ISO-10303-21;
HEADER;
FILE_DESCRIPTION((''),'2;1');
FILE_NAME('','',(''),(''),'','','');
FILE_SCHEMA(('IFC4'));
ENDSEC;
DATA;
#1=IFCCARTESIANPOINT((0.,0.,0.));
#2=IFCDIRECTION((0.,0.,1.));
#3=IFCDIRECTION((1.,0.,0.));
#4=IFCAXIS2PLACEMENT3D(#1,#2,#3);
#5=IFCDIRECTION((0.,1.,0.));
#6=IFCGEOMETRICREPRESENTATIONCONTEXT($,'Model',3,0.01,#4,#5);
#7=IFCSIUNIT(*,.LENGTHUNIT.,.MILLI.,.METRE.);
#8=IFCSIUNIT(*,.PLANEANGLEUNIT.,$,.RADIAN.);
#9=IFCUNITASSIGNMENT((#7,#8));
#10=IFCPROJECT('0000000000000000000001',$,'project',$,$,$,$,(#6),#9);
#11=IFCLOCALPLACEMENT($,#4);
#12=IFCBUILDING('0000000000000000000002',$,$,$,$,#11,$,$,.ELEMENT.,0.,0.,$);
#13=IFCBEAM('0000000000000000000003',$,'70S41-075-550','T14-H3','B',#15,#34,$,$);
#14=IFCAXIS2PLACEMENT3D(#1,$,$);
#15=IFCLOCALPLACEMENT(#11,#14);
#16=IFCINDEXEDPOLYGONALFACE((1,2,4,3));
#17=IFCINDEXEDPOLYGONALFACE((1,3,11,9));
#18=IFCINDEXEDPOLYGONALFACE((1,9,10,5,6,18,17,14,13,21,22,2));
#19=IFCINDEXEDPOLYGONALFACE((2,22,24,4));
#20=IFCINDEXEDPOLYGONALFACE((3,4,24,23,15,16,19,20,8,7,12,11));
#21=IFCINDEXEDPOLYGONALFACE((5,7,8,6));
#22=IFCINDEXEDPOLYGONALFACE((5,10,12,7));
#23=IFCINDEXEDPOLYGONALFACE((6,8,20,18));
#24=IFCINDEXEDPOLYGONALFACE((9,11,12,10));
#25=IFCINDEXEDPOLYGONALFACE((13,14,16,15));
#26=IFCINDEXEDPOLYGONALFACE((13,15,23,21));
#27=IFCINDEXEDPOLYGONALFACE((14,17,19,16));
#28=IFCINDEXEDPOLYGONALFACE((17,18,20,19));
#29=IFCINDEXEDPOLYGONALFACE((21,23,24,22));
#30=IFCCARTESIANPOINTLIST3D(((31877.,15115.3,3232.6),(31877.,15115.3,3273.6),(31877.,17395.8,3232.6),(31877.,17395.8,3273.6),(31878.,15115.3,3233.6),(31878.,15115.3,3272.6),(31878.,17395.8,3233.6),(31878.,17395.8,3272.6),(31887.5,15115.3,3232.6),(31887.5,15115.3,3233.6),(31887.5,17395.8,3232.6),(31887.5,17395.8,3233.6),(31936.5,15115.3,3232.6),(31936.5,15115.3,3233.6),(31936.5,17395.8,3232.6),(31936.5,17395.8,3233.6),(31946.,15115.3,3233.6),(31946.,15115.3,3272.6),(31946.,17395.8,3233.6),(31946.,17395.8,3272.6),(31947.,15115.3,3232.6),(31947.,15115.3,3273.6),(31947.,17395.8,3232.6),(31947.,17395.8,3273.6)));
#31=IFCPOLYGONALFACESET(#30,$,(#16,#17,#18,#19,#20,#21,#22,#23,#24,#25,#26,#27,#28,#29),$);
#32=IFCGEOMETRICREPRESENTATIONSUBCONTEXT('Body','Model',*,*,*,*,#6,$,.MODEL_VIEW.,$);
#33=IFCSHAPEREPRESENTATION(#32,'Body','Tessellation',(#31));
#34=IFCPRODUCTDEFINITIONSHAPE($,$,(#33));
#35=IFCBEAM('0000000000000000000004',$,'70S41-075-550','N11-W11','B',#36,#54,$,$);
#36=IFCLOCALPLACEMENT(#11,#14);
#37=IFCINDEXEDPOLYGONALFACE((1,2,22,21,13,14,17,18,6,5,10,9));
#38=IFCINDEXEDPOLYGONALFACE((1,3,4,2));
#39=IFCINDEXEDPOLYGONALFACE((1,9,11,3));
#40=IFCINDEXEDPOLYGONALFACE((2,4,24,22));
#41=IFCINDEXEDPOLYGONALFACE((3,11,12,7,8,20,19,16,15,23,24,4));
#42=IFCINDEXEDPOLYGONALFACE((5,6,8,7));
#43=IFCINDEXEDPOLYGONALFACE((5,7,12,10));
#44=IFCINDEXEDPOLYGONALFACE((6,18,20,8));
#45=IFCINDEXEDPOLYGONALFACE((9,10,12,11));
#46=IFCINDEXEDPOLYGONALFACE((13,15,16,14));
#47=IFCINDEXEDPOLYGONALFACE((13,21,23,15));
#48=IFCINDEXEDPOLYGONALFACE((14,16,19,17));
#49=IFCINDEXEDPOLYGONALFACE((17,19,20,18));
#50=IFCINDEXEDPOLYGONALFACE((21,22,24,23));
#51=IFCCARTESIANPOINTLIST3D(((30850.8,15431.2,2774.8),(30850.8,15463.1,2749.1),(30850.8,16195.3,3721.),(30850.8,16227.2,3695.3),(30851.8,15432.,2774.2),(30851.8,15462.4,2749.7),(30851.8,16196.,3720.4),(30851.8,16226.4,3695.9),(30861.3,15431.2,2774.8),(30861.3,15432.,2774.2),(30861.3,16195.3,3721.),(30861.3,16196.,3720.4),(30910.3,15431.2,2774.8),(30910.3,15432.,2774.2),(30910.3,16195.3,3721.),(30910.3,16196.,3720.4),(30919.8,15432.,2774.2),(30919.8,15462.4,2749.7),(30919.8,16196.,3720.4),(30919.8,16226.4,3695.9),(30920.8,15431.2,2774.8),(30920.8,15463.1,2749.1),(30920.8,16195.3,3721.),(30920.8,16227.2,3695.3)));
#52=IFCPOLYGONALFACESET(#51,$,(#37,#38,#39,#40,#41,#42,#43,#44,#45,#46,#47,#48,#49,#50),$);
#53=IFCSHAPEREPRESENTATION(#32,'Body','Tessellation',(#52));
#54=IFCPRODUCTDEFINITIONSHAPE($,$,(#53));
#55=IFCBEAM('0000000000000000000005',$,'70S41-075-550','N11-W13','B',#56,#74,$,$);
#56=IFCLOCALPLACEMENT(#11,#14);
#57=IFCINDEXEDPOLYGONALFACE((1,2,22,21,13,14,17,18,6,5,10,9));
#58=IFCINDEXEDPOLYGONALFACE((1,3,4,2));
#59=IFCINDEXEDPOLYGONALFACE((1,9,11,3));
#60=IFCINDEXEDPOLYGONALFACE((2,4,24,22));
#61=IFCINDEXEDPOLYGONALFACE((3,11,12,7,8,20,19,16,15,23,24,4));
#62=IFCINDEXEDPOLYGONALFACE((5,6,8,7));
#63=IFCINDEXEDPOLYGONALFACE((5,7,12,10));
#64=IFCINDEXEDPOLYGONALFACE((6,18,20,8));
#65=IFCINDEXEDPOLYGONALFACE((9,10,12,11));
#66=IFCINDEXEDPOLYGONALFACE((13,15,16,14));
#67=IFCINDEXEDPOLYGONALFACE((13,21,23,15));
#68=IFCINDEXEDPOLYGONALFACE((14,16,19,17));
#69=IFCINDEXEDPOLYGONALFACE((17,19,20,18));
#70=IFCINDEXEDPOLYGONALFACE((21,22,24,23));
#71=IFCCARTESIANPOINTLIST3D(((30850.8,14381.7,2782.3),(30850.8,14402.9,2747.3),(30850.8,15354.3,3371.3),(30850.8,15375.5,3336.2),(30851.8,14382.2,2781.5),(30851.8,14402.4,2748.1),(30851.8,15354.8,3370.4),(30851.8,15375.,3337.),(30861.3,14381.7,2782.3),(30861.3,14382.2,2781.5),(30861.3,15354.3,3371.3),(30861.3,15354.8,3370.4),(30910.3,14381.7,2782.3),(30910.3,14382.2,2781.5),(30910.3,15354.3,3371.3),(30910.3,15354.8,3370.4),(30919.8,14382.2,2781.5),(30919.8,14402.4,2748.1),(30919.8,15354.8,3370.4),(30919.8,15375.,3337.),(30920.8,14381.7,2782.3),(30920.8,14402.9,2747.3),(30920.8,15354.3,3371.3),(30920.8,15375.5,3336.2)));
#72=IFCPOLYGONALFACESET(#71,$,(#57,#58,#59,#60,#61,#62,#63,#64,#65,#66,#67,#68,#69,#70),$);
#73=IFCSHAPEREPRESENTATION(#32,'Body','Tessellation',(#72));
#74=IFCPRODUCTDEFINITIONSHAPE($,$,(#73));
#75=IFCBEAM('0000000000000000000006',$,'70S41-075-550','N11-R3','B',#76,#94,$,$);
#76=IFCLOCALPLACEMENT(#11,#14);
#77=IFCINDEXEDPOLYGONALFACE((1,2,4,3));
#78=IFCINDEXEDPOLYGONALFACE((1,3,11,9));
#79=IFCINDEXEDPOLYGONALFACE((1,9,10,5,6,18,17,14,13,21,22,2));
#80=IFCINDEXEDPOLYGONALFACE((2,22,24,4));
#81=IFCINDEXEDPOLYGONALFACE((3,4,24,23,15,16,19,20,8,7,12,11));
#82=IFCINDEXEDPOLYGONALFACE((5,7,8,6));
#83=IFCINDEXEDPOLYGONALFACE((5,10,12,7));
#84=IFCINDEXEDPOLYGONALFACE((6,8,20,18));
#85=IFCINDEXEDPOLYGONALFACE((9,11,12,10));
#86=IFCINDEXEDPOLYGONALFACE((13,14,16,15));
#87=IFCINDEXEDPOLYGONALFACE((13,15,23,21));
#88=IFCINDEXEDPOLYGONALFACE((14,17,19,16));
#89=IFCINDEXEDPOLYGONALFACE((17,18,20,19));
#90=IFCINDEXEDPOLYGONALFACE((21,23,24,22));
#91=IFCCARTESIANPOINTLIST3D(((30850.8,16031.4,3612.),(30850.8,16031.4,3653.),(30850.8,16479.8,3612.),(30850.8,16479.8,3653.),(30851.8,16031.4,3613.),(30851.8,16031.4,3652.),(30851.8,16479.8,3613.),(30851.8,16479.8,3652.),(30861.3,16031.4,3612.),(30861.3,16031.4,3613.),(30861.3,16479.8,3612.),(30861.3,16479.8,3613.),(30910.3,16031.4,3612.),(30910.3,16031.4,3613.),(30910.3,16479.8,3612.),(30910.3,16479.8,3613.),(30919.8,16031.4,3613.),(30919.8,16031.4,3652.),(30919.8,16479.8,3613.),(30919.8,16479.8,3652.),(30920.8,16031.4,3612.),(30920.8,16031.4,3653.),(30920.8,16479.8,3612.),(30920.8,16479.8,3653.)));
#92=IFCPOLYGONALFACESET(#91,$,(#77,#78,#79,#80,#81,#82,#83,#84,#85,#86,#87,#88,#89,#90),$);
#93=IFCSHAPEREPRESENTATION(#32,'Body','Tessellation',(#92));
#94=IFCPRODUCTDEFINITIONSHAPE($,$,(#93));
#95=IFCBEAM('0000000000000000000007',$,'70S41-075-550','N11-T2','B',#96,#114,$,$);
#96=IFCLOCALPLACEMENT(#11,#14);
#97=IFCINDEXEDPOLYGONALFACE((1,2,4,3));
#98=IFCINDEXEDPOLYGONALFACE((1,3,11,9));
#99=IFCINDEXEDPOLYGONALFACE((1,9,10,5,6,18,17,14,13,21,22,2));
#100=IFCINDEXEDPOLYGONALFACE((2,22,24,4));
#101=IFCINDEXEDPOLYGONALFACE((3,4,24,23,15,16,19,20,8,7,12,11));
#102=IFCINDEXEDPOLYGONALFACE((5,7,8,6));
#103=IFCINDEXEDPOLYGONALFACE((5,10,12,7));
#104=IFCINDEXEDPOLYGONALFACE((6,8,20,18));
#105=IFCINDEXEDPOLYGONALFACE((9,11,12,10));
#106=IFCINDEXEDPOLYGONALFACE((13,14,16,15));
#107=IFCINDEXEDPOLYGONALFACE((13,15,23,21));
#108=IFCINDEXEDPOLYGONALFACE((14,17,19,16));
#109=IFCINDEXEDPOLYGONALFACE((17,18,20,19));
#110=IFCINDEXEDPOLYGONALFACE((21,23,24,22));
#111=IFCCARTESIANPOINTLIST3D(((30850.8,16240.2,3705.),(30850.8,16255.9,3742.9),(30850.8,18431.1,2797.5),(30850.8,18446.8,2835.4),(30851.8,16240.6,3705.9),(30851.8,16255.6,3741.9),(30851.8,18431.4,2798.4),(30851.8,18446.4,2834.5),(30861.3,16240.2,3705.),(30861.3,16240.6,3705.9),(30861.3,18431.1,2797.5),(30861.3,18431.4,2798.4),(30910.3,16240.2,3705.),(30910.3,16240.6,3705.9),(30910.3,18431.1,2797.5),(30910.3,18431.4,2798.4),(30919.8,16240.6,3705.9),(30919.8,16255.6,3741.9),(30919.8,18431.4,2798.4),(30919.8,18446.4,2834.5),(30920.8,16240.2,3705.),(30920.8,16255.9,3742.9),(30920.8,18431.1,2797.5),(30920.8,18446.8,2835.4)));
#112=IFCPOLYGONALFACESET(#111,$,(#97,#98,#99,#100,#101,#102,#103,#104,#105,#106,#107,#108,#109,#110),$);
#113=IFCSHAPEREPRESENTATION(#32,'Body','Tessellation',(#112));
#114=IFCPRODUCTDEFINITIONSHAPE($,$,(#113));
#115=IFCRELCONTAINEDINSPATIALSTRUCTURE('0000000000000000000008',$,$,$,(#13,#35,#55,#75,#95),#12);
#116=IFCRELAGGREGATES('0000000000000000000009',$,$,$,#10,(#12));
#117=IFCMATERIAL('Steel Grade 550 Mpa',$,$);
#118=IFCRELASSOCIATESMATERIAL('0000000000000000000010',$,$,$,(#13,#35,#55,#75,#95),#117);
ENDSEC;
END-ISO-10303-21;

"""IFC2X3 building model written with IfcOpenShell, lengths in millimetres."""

from ifc_helpers import new_model, si_unit, direction, frame, origin, origin_with_axes, origin_2d_with_axis, place, context, subcontext, project, spatial, c_section, extrude, source, transform, mapped, material, element, save


model = new_model("IFC2X3")

# Units and contexts
model_context = context("Model", 3, precision=0.01, world=origin_with_axes(), true_north=direction((0.0, 1.0, 0.0)))
body_context = subcontext(model_context, "Body", "Model", "MODEL_VIEW")
ifc_project = project(units=[si_unit("LENGTHUNIT", "METRE", prefix="MILLI"), si_unit("PLANEANGLEUNIT", "RADIAN")], contexts=[model_context])

# Building
building_placement = place(None, origin_with_axes())
building = spatial("IfcBuilding", under=ifc_project, at=building_placement, CompositionType="ELEMENT", ElevationOfRefHeight=0.0, ElevationOfTerrain=0.0)

# Shared definitions
ifc_material = material(Name="Steel Grade 550 Mpa")

# Beams
shared_shape_1 = source(origin(), body_context, "Body", "SweptSolid", [
    extrude(c_section(Depth=70.0, Width=41.0, WallThickness=1.0, Girth=10.5, at=origin_2d_with_axis()), origin_with_axes(), (0.0, 0.0, 1.0), 2280.4),
])
beam_1_placement = place(None, frame((31912.0, 15115.3, 3253.1), z_axis=(0.0, 1.0, 0.0), x_axis=(0.0, 0.0, -1.0)))
element("IfcBeam", 1, at=beam_1_placement, inside=building, material=ifc_material, Name="70S41-075-550", Description="T14-H3", ObjectType="B", context=body_context, shape_type="MappedRepresentation", body=[
    mapped(shared_shape_1, transform((0.0, 0.0, 0.0), scale=1.0)),
])
shared_shape_2 = source(origin(), body_context, "Body", "SweptSolid", [
    extrude(c_section(Depth=70.0, Width=41.0, WallThickness=1.0, Girth=10.5, at=origin_2d_with_axis()), origin_with_axes(), (0.0, 0.0, 1.0), 1216.2),
])
beam_2_placement = place(None, frame((30885.8, 16211.2, 3708.2), z_axis=(0.0, -0.62822, -0.778036), x_axis=(0.0, -0.778036, 0.62822)))
element("IfcBeam", 2, at=beam_2_placement, inside=building, material=ifc_material, Name="70S41-075-550", Description="N11-W11", ObjectType="B", context=body_context, shape_type="MappedRepresentation", body=[
    mapped(shared_shape_2, transform((0.0, 0.0, 0.0), scale=1.0)),
])
shared_shape_3 = source(origin(), body_context, "Body", "SweptSolid", [
    extrude(c_section(Depth=70.0, Width=41.0, WallThickness=1.0, Girth=10.5, at=origin_2d_with_axis()), origin_with_axes(), (0.0, 0.0, 1.0), 1137.0),
])
beam_3_placement = place(None, frame((30885.8, 15364.9, 3353.7), z_axis=(0.0, -0.855412, -0.517948), x_axis=(0.0, -0.517948, 0.855412)))
element("IfcBeam", 3, at=beam_3_placement, inside=building, material=ifc_material, Name="70S41-075-550", Description="N11-W13", ObjectType="B", context=body_context, shape_type="MappedRepresentation", body=[
    mapped(shared_shape_3, transform((0.0, 0.0, 0.0), scale=1.0)),
])
shared_shape_4 = source(origin(), body_context, "Body", "SweptSolid", [
    extrude(c_section(Depth=70.0, Width=41.0, WallThickness=1.0, Girth=10.5, at=origin_2d_with_axis()), origin_with_axes(), (0.0, 0.0, 1.0), 448.4),
])
beam_4_placement = place(None, frame((30885.8, 16031.4, 3632.5), z_axis=(0.0, 1.0, 0.0), x_axis=(0.0, 0.0, -1.0)))
element("IfcBeam", 4, at=beam_4_placement, inside=building, material=ifc_material, Name="70S41-075-550", Description="N11-R3", ObjectType="B", context=body_context, shape_type="MappedRepresentation", body=[
    mapped(shared_shape_4, transform((0.0, 0.0, 0.0), scale=1.0)),
])
shared_shape_5 = source(origin(), body_context, "Body", "SweptSolid", [
    extrude(c_section(Depth=70.0, Width=41.0, WallThickness=1.0, Girth=10.5, at=origin_2d_with_axis()), origin_with_axes(), (0.0, 0.0, 1.0), 2371.3),
])
beam_5_placement = place(None, frame((30885.8, 16248.1, 3723.9), z_axis=(0.0, 0.92388, -0.382683), x_axis=(0.0, -0.382683, -0.92388)))
element("IfcBeam", 5, at=beam_5_placement, inside=building, material=ifc_material, Name="70S41-075-550", Description="N11-T2", ObjectType="B", context=body_context, shape_type="MappedRepresentation", body=[
    mapped(shared_shape_5, transform((0.0, 0.0, 0.0), scale=1.0)),
])

save(model, "model.ifc")
